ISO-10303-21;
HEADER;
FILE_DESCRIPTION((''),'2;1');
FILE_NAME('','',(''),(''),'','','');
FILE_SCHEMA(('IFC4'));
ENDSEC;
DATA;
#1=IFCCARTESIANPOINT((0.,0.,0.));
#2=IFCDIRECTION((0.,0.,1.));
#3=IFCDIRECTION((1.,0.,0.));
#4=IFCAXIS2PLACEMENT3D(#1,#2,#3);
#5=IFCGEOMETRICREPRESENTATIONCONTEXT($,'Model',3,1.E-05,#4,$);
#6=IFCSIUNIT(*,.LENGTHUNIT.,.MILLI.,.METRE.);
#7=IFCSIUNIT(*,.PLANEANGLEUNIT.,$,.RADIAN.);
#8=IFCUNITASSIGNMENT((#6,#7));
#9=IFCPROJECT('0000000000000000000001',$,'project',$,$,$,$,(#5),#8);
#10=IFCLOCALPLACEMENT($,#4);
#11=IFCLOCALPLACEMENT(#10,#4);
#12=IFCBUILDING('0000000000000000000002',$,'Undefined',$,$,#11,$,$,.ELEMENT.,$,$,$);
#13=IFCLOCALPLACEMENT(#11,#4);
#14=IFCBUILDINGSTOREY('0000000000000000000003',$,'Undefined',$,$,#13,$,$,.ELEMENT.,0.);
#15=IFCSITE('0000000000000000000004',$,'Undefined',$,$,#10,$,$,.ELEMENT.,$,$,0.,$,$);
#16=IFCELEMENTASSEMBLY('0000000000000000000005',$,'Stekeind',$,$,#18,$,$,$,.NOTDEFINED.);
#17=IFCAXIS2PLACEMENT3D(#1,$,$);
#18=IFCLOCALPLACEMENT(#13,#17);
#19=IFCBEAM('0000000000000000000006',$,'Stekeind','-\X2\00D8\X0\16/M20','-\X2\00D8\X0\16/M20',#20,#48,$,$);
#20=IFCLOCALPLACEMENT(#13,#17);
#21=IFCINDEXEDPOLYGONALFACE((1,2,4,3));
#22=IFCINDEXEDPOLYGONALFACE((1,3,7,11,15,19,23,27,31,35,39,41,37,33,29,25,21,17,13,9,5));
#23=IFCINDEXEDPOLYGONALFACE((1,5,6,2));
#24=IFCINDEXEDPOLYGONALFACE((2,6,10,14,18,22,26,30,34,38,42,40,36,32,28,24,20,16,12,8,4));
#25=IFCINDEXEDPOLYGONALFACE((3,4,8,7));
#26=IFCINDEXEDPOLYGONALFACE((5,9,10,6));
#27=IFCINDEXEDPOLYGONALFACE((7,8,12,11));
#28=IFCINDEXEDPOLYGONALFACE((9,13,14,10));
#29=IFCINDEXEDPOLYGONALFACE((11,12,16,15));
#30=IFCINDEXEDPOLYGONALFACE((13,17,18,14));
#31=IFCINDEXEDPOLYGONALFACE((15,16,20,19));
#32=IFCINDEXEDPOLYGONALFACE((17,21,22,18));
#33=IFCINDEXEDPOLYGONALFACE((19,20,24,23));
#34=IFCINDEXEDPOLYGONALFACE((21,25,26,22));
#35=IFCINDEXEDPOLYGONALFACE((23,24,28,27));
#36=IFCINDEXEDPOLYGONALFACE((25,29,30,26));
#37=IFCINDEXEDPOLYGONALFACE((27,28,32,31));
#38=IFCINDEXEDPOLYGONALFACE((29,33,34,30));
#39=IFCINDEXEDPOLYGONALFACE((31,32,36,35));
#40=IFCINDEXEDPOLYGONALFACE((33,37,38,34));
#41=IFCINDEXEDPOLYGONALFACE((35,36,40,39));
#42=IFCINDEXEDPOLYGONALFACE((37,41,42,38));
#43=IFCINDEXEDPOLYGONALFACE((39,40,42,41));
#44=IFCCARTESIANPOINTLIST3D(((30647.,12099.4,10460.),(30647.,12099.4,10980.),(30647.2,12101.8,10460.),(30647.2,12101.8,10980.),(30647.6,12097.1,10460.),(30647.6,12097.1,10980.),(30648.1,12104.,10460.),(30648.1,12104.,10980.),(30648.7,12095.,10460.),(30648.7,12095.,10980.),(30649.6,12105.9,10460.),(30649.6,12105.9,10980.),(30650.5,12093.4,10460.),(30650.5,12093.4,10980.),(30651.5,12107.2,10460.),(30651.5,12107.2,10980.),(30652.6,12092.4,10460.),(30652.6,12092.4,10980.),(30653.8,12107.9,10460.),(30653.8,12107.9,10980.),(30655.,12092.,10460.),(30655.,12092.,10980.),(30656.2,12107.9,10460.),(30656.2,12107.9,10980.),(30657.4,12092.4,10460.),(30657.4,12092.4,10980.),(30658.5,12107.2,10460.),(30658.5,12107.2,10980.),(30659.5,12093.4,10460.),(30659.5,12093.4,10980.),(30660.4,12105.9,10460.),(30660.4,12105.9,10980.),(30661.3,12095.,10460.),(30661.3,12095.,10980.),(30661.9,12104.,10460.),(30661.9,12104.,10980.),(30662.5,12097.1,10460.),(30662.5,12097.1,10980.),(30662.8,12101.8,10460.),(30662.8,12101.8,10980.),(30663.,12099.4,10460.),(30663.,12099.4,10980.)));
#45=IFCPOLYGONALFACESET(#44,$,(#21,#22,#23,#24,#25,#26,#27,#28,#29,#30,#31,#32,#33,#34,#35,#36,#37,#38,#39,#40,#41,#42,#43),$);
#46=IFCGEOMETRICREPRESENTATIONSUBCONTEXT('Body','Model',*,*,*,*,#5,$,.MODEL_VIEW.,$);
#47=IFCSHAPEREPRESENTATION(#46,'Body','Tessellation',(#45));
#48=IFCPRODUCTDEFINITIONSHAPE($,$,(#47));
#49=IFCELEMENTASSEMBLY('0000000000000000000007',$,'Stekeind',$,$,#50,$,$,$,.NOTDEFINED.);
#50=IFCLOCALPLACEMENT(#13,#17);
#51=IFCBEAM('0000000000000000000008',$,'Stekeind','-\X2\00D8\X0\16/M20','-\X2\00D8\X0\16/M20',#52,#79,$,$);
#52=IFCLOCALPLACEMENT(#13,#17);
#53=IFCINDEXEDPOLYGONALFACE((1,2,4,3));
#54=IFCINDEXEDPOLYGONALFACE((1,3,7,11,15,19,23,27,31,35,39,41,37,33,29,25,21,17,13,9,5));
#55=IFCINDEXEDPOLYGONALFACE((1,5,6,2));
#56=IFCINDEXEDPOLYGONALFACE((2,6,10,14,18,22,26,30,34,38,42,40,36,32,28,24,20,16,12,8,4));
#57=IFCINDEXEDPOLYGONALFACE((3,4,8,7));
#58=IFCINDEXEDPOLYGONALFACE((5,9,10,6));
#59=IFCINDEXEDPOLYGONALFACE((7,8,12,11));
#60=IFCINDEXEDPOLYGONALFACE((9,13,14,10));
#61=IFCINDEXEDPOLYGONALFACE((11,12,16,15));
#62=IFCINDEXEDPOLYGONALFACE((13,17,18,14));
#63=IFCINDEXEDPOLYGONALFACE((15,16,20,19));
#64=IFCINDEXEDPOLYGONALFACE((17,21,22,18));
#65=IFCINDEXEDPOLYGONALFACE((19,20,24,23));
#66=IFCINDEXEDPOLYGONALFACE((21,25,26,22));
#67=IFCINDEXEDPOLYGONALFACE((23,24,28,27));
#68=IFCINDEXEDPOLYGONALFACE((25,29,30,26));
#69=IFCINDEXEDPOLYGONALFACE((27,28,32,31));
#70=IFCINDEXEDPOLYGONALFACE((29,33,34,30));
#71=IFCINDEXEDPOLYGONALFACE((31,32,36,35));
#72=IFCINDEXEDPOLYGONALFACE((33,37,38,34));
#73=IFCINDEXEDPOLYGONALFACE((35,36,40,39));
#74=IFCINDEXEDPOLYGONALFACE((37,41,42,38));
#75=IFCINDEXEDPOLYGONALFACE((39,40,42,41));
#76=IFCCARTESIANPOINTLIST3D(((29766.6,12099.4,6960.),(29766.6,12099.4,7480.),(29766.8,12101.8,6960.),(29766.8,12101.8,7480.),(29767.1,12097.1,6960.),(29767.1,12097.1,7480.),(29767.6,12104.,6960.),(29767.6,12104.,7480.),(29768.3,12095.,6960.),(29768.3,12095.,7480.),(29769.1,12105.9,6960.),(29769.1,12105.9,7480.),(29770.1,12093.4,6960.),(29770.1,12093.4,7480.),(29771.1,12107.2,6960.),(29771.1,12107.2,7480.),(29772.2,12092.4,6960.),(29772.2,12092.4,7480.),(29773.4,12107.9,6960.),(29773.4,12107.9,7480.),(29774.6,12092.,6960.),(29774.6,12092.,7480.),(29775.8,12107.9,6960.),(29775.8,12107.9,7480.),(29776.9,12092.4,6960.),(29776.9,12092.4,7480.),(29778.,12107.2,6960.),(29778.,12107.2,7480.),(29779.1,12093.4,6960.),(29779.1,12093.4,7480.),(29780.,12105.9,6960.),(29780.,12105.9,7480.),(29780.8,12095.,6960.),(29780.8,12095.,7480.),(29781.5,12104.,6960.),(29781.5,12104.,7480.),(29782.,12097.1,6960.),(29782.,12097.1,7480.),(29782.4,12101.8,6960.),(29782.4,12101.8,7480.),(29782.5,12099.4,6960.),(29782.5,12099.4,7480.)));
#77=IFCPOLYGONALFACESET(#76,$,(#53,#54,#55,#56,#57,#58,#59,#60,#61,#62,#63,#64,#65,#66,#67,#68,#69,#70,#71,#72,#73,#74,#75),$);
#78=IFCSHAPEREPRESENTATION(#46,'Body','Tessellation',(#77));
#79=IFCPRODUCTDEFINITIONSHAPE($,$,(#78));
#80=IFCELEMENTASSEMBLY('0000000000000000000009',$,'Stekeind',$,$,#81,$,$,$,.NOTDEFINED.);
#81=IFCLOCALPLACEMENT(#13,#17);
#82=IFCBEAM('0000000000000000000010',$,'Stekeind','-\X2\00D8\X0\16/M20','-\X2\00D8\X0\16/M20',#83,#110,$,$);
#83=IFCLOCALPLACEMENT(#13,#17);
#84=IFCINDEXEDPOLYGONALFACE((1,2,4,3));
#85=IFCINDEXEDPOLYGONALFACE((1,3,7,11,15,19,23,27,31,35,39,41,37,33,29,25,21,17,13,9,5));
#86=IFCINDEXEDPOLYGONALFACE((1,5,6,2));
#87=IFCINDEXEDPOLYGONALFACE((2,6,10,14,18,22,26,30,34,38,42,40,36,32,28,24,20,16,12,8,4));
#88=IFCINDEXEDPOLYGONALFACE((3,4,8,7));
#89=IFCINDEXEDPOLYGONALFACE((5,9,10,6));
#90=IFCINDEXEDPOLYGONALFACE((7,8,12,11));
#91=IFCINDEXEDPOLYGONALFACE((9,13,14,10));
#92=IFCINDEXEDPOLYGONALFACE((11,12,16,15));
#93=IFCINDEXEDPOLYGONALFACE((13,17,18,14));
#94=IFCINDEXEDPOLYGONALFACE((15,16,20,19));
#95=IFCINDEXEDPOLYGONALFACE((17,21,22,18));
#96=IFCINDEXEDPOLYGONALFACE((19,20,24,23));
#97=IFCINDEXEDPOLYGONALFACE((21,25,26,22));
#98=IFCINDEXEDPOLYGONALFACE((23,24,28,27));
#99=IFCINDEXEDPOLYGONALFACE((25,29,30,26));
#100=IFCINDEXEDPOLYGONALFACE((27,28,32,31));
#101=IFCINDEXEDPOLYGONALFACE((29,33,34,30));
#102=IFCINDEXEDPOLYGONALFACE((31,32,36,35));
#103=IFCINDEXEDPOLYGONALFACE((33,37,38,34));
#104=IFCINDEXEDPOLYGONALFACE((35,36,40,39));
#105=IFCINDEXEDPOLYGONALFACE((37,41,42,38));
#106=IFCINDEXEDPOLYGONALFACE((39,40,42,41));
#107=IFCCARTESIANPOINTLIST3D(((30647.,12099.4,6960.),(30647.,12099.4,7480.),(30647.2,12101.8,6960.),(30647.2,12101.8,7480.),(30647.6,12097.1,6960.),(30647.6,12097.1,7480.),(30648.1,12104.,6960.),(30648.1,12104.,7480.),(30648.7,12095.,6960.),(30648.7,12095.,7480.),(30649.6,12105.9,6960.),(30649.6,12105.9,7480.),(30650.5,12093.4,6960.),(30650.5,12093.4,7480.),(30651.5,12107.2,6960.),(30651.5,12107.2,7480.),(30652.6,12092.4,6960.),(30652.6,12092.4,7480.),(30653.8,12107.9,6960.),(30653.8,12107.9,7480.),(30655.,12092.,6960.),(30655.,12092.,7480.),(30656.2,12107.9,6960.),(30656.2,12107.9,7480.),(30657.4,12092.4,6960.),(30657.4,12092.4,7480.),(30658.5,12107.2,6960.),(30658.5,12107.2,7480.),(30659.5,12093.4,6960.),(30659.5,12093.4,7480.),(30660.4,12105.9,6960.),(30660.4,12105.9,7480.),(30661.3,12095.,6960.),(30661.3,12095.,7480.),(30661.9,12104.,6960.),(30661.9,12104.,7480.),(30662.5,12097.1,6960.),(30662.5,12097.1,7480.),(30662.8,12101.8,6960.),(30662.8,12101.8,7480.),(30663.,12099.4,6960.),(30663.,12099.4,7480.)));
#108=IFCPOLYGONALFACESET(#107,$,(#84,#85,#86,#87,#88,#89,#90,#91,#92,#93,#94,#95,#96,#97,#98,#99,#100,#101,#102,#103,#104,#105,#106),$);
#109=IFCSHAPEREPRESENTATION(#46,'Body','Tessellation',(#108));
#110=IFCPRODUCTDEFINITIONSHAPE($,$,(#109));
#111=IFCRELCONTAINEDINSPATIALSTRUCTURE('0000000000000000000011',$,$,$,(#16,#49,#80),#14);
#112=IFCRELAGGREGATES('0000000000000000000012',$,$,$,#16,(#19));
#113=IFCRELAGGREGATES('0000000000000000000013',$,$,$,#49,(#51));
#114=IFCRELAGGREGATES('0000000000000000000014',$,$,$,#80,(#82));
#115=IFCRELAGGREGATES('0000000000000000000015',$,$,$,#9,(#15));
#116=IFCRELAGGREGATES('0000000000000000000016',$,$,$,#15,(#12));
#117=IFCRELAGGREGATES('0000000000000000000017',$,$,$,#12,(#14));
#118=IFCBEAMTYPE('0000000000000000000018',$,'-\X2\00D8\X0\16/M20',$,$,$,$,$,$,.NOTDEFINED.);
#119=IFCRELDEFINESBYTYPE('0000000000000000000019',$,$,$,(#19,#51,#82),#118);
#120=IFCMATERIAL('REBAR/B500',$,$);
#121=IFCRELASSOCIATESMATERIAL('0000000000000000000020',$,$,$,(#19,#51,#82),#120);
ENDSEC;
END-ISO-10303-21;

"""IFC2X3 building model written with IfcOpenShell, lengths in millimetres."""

from ifc_helpers import new_model, si_unit, frame, origin_with_axes, origin_2d_with_axis, place, context, subcontext, project, spatial, circle, extrude, material, type_object, element, aggregate, save


model = new_model("IFC2X3")

# Units and contexts
model_context = context("Model", 3, precision=1e-05, world=origin_with_axes())
body_context = subcontext(model_context, "Body", "Model", "MODEL_VIEW")
ifc_project = project(units=[si_unit("LENGTHUNIT", "METRE", prefix="MILLI"), si_unit("PLANEANGLEUNIT", "RADIAN")], contexts=[model_context])

# Site, building, storey
site_placement = place(None, origin_with_axes())
site = spatial("IfcSite", under=ifc_project, at=site_placement, Name="Undefined", CompositionType="ELEMENT", RefElevation=0.0)
building_placement = place(site_placement, origin_with_axes())
building = spatial("IfcBuilding", under=site, at=building_placement, Name="Undefined", CompositionType="ELEMENT")
storey_placement = place(building_placement, origin_with_axes())
storey = spatial("IfcBuildingStorey", under=building, at=storey_placement, Name="Undefined", CompositionType="ELEMENT", Elevation=0.0)

# Element assemblies, beams
ifc_material_1 = material(Name="REBAR/B500")
beam_type_1 = type_object("IfcBeamType", Name="-Ø16/M20", PredefinedType="NOTDEFINED")
assembly_1_placement = place(storey_placement, origin_with_axes())
assembly_1 = element("IfcElementAssembly", 1, at=assembly_1_placement, inside=storey, Name="Stekeind", PredefinedType="NOTDEFINED")
beam_1_placement = place(assembly_1_placement, frame((30655.0, 12100.0, 10980.0), z_axis=(1.0, 0.0, 0.0), x_axis=(0.0, 0.0, -1.0)))
beam_1 = element("IfcBeam", 2, at=beam_1_placement, type_object=beam_type_1, material=ifc_material_1, Name="Stekeind", Description="-Ø16/M20", ObjectType="-Ø16/M20", context=body_context, shape_type="SweptSolid", body=[
    extrude(circle(Radius=8.0, at=origin_2d_with_axis()), frame((520.0, 0.0, 0.0), z_axis=(-1.0, 0.0, 0.0), x_axis=(0.0, -1.0, 0.0)), (0.0, 0.0, 1.0), 520.0),
])
aggregate(assembly_1, [beam_1])
assembly_2_placement = place(storey_placement, origin_with_axes())
assembly_2 = element("IfcElementAssembly", 3, at=assembly_2_placement, inside=storey, Name="Stekeind", PredefinedType="NOTDEFINED")
beam_2_placement = place(assembly_2_placement, frame((29774.6, 12100.0, 7480.0), z_axis=(1.0, 0.0, 0.0), x_axis=(0.0, 0.0, -1.0)))
beam_2 = element("IfcBeam", 4, at=beam_2_placement, type_object=beam_type_1, material=ifc_material_1, Name="Stekeind", Description="-Ø16/M20", ObjectType="-Ø16/M20", context=body_context, shape_type="SweptSolid", body=[
    extrude(circle(Radius=8.0, at=origin_2d_with_axis()), frame((520.0, 0.0, 0.0), z_axis=(-1.0, 0.0, 0.0), x_axis=(0.0, -1.0, 0.0)), (0.0, 0.0, 1.0), 520.0),
])
aggregate(assembly_2, [beam_2])
assembly_3_placement = place(storey_placement, origin_with_axes())
assembly_3 = element("IfcElementAssembly", 5, at=assembly_3_placement, inside=storey, Name="Stekeind", PredefinedType="NOTDEFINED")
beam_3_placement = place(assembly_3_placement, frame((30655.0, 12100.0, 7480.0), z_axis=(1.0, 0.0, 0.0), x_axis=(0.0, 0.0, -1.0)))
beam_3 = element("IfcBeam", 6, at=beam_3_placement, type_object=beam_type_1, material=ifc_material_1, Name="Stekeind", Description="-Ø16/M20", ObjectType="-Ø16/M20", context=body_context, shape_type="SweptSolid", body=[
    extrude(circle(Radius=8.0, at=origin_2d_with_axis()), frame((520.0, 0.0, 0.0), z_axis=(-1.0, 0.0, 0.0), x_axis=(0.0, -1.0, 0.0)), (0.0, 0.0, 1.0), 520.0),
])
aggregate(assembly_3, [beam_3])

save(model, "model.ifc")
